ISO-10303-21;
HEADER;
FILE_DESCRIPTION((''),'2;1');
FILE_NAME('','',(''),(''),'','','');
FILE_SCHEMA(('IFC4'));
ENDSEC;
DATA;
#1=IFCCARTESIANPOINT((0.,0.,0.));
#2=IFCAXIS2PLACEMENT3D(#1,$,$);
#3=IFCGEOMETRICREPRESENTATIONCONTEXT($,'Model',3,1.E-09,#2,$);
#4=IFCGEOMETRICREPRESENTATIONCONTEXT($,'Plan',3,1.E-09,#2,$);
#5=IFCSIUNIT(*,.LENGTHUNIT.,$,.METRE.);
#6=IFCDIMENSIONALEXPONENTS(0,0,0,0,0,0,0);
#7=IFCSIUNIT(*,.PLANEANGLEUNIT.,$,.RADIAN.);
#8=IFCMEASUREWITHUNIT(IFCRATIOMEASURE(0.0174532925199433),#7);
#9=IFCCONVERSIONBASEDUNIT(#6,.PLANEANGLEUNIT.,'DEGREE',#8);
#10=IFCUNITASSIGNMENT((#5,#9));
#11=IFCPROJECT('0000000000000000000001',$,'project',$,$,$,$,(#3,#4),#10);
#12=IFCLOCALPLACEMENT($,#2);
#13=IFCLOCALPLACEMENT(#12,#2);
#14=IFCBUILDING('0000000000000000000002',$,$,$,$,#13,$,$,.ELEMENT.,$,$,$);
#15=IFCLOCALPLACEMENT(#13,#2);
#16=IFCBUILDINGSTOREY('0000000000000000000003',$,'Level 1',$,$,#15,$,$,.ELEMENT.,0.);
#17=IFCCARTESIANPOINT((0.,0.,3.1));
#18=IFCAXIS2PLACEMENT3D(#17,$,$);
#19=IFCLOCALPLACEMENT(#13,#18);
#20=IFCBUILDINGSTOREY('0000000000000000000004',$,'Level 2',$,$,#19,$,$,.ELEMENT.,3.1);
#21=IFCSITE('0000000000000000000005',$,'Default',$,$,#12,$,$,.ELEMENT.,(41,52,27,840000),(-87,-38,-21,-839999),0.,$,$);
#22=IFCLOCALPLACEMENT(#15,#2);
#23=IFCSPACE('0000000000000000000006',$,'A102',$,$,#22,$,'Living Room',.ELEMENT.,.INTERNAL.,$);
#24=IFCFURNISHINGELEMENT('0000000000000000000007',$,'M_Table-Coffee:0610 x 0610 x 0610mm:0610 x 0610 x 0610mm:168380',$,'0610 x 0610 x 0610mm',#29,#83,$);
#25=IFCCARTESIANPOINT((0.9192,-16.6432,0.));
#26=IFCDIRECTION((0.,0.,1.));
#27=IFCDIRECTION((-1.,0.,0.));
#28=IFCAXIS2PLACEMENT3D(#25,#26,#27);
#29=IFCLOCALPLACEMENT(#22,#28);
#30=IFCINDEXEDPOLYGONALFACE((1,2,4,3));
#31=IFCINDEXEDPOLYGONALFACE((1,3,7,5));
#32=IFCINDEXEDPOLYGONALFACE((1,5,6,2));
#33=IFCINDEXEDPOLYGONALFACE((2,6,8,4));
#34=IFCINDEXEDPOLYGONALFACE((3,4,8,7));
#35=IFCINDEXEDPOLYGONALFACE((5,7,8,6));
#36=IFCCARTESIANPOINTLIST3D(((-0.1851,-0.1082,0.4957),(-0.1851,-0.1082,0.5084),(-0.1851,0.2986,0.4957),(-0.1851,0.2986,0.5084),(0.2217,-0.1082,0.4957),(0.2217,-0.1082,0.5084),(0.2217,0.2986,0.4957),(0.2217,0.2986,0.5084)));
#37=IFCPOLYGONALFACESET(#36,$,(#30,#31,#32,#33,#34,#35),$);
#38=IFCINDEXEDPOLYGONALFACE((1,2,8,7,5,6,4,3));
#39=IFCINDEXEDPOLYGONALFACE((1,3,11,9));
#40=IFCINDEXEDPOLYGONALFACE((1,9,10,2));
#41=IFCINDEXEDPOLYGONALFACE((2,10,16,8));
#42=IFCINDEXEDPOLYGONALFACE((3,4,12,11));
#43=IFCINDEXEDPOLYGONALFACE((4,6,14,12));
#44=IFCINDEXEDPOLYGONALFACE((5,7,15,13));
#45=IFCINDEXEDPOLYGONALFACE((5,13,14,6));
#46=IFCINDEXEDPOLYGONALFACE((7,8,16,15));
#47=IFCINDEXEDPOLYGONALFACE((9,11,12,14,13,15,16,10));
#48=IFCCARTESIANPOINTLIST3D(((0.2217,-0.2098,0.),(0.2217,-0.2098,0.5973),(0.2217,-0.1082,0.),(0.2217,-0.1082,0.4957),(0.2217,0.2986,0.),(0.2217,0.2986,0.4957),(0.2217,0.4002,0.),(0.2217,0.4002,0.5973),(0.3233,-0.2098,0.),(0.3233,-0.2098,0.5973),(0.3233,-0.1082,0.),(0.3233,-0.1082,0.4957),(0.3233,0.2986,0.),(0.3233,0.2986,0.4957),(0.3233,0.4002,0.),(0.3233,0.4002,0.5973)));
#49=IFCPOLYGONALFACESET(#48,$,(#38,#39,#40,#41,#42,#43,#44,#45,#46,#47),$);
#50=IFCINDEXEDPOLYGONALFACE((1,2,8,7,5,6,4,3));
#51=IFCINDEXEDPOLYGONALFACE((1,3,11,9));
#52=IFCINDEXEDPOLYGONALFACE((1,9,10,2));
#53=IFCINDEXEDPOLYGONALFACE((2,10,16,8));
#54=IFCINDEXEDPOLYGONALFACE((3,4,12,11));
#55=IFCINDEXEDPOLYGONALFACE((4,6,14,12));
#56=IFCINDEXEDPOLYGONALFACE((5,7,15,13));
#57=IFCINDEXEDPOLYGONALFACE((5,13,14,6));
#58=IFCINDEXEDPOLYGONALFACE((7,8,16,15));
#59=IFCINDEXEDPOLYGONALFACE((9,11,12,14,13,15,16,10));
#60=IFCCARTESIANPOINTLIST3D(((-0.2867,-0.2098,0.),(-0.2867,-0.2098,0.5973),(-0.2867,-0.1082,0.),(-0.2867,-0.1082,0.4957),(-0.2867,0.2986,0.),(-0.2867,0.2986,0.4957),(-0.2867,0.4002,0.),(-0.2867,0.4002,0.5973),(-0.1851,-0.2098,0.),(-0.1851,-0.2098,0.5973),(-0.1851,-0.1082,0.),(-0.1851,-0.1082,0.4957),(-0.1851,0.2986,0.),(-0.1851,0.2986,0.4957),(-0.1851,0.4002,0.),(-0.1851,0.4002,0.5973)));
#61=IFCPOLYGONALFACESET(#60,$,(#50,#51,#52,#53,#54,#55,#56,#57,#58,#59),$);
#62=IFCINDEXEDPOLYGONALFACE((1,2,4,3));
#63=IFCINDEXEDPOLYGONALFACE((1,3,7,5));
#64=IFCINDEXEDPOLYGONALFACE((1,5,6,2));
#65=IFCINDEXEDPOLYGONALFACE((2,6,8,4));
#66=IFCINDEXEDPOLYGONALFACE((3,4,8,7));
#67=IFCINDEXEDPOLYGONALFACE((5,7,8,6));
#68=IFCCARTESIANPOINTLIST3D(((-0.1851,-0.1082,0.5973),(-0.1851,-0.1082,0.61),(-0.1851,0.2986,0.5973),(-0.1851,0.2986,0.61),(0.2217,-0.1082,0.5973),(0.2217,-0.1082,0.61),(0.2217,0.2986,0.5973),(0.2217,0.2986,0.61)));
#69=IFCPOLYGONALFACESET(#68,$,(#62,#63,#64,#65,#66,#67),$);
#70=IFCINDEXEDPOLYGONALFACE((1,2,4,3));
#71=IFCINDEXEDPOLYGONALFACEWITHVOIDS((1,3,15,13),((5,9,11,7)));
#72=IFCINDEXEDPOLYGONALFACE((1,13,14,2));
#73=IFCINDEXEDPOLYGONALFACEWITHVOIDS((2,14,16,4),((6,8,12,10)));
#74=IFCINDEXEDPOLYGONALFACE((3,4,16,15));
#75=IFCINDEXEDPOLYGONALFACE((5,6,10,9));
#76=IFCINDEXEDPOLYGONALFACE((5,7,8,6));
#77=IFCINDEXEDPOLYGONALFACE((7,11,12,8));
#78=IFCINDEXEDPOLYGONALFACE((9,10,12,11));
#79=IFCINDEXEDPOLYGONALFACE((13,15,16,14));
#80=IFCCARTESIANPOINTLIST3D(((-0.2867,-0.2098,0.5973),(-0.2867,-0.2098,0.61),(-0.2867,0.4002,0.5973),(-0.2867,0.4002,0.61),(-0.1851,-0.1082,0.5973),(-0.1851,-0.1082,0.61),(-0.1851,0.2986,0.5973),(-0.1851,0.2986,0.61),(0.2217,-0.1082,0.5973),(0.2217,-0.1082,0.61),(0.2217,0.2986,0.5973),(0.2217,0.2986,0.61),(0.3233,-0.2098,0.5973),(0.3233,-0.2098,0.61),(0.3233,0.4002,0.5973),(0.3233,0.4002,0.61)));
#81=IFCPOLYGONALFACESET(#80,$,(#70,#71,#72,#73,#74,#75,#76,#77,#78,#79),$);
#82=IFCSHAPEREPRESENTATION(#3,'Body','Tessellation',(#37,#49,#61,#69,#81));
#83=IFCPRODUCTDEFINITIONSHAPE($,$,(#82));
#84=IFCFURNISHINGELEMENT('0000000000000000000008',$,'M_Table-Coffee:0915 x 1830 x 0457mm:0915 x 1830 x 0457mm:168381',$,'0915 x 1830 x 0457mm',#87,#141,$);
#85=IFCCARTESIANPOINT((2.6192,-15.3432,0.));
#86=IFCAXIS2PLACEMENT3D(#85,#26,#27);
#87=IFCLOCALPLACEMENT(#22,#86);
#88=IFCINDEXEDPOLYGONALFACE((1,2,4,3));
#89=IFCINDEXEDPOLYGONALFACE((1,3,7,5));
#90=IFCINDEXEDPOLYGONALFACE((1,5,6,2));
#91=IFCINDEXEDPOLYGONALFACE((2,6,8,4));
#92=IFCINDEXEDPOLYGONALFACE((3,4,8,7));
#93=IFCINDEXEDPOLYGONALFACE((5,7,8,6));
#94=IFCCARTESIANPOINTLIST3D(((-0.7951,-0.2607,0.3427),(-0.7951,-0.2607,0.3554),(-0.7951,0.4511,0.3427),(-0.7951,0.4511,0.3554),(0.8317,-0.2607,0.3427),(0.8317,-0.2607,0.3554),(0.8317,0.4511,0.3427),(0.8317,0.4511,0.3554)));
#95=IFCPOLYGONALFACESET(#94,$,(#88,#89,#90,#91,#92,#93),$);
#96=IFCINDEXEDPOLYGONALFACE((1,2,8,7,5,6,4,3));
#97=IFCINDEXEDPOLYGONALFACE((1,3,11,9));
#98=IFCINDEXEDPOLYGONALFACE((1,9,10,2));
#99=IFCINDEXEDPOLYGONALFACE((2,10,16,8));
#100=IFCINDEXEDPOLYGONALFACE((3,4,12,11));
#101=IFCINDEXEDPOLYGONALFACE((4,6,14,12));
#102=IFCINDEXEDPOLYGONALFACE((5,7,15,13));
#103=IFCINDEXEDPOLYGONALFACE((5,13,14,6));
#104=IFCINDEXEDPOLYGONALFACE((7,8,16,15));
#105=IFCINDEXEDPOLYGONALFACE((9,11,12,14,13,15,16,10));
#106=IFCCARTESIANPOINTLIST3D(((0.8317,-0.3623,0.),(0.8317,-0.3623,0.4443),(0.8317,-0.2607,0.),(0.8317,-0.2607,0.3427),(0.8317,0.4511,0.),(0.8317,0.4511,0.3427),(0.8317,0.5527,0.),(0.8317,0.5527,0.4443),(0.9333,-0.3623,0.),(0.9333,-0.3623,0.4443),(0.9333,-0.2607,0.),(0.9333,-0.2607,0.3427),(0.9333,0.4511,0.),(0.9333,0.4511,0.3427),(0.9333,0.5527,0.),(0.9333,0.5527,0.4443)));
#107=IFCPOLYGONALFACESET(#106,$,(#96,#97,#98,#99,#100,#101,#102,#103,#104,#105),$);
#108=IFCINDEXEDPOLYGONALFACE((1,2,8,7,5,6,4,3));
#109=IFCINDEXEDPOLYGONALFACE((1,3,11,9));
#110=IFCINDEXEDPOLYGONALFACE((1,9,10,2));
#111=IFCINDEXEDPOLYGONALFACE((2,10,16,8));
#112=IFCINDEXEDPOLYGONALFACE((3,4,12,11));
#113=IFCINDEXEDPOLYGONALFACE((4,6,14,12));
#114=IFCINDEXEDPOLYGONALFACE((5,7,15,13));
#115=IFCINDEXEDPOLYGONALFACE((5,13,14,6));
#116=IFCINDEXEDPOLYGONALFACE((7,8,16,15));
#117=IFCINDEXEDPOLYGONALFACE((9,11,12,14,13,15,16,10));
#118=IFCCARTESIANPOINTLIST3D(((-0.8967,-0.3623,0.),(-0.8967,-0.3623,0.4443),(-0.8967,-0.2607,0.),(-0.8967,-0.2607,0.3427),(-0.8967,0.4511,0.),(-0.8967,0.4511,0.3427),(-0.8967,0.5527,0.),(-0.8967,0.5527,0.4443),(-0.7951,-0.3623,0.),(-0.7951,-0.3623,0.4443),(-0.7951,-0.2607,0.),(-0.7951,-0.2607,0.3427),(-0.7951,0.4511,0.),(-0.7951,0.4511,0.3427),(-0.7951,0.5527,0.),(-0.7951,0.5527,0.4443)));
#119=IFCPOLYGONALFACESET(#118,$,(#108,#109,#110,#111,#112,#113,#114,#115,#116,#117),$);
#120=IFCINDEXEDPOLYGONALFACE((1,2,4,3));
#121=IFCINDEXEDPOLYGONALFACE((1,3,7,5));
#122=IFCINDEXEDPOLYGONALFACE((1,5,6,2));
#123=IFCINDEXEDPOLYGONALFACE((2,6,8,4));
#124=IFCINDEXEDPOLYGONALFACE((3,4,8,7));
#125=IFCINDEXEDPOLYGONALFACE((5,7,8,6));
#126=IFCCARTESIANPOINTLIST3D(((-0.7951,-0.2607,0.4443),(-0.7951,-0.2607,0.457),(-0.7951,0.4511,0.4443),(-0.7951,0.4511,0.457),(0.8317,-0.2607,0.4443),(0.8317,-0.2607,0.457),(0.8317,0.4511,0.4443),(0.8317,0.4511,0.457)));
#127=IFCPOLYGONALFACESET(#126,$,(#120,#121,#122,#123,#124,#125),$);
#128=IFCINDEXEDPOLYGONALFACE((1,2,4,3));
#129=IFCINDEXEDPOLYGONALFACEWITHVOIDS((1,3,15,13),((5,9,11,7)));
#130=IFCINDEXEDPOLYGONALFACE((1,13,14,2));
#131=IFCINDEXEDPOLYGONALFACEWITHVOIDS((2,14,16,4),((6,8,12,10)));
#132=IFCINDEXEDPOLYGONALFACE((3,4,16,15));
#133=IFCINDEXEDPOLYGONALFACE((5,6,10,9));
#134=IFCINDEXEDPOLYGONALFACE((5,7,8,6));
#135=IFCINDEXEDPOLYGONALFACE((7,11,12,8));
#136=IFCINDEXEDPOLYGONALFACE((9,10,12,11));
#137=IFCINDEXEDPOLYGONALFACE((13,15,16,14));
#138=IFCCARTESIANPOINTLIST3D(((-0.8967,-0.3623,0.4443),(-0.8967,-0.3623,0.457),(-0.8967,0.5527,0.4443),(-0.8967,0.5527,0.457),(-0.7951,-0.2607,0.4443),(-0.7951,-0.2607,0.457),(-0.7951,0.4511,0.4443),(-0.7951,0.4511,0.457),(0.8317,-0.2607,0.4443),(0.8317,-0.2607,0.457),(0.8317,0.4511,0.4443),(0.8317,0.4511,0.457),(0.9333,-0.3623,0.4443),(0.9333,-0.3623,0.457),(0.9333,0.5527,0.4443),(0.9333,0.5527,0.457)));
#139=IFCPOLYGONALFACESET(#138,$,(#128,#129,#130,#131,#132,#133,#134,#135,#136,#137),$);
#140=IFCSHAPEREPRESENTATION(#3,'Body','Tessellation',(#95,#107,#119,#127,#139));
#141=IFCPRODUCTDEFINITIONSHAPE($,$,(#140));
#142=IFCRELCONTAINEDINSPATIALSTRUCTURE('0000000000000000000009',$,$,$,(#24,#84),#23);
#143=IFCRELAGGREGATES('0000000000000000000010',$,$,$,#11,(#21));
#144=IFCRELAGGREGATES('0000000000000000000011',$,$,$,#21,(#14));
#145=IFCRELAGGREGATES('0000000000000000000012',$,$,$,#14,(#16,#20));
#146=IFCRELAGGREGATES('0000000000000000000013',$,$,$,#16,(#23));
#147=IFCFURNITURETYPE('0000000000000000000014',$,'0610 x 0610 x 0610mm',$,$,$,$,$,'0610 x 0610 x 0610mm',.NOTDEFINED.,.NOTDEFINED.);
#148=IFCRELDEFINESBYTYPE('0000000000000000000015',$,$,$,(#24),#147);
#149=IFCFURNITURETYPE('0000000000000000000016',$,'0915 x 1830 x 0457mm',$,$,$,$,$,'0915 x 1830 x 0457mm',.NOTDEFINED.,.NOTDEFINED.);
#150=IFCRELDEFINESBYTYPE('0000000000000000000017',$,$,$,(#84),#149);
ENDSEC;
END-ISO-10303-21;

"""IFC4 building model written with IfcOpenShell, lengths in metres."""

from ifc_helpers import new_model, entity, si_unit, converted_unit, frame, origin, origin_2d_with_axis, place, context, project, spatial, polyline, rectangle, outline, extrude, source, transform, mapped, type_object, type_shapes, element, save


model = new_model("IFC4")

# Units and contexts
model_context = context("Model", 3, precision=1e-09, world=origin())
plan_context = context("Plan", 3, precision=1e-09, world=origin())
ifc_project = project(units=[si_unit("LENGTHUNIT", "METRE"), converted_unit("PLANEANGLEUNIT", "DEGREE", entity("IfcRatioMeasure", 0.0174532925199433), si_unit("PLANEANGLEUNIT", "RADIAN"), dimensions=[0, 0, 0, 0, 0, 0, 0])], contexts=[model_context, plan_context])

# Site, building, storey
site_placement = place(None, origin())
site = spatial("IfcSite", under=ifc_project, at=site_placement, Name="Default", CompositionType="ELEMENT", RefLatitude=(41, 52, 27, 840000), RefLongitude=(-87, -38, -21, -839999), RefElevation=0.0)
building_placement = place(site_placement, origin())
building = spatial("IfcBuilding", under=site, at=building_placement, CompositionType="ELEMENT")
storey_1_placement = place(building_placement, origin())
storey_1 = spatial("IfcBuildingStorey", under=building, at=storey_1_placement, Name="Level 1", CompositionType="ELEMENT", Elevation=0.0)

# Shared definitions
storey_2_placement = place(building_placement, frame((0.0, 0.0, 3.1)))
storey_2 = spatial("IfcBuildingStorey", under=building, at=storey_2_placement, Name="Level 2", CompositionType="ELEMENT", Elevation=3.1)

# Shared definitions
space_1_placement = place(storey_1_placement, origin())
space_1 = spatial("IfcSpace", under=storey_1, at=space_1_placement, Name="A102", LongName="Living Room", CompositionType="ELEMENT", PredefinedType="INTERNAL")

# Furnishing elements
furniture_type_1 = type_object("IfcFurnitureType", Name="0610 x 0610 x 0610mm", ElementType="0610 x 0610 x 0610mm", AssemblyPlace="NOTDEFINED")
shared_shape_1 = source(origin(), model_context, "Body", "SweptSolid", [
    extrude(rectangle(XDim=0.4068, YDim=0.4068, at=origin_2d_with_axis()), frame((0.0183, 0.0952, 0.4957), z_axis=(0.0, 0.0, 1.0), x_axis=(-1.0, 0.0, 0.0)), (0.0, 0.0, 1.0), 0.0127),
    extrude(outline(polyline([(-0.2732, -0.305), (0.324, -0.305), (0.324, 0.305), (-0.2732, 0.305), (-0.2732, 0.2034), (0.2225, 0.2034), (0.2225, -0.2034), (-0.2732, -0.2034), (-0.2732, -0.305)])), frame((0.2217, 0.0952, 0.2732), z_axis=(1.0, 0.0, 0.0), x_axis=(0.0, 0.0, 1.0)), (0.0, 0.0, 1.0), 0.1016),
    extrude(outline(polyline([(-0.305, -0.3241), (0.305, -0.3241), (0.305, 0.2733), (0.2034, 0.2733), (0.2034, -0.2224), (-0.2034, -0.2224), (-0.2034, 0.2733), (-0.305, 0.2733), (-0.305, -0.3241)])), frame((-0.2867, 0.0952, 0.2733), z_axis=(1.0, 0.0, 0.0), x_axis=(0.0, -1.0, 0.0)), (0.0, 0.0, 1.0), 0.1016),
    extrude(rectangle(XDim=0.4068, YDim=0.4068, at=origin_2d_with_axis()), frame((0.0183, 0.0952, 0.5973), z_axis=(0.0, 0.0, 1.0), x_axis=(-1.0, 0.0, 0.0)), (0.0, 0.0, 1.0), 0.0127),
    extrude(outline(polyline([(-0.305, -0.305), (0.305, -0.305), (0.305, 0.305), (-0.305, 0.305), (-0.305, -0.305)]), holes=[polyline([(-0.2034, -0.2034), (-0.2034, 0.2034), (0.2034, 0.2034), (0.2034, -0.2034), (-0.2034, -0.2034)])]), frame((0.0183, 0.0952, 0.5973), z_axis=(0.0, 0.0, 1.0), x_axis=(-1.0, 0.0, 0.0)), (0.0, 0.0, 1.0), 0.0127),
])
type_shapes(furniture_type_1, [shared_shape_1])
for number, where, z_axis, x_axis, name in (
    (1, (0.9192, -16.6432, 0.0), (0.0, 0.0, 1.0), (-1.0, 0.0, 0.0), "M_Table-Coffee:0610 x 0610 x 0610mm:0610 x 0610 x 0610mm:168380"),
):
    element("IfcFurnishingElement", number, at=place(space_1_placement, frame(where, z_axis=z_axis, x_axis=x_axis)), inside=space_1, type_object=furniture_type_1, Name=name, ObjectType="0610 x 0610 x 0610mm", context=model_context, shape_type="MappedRepresentation", body=[
        mapped(shared_shape_1, transform((0.0, 0.0, 0.0), scale=1.0)),
    ])
furniture_type_2 = type_object("IfcFurnitureType", Name="0915 x 1830 x 0457mm", ElementType="0915 x 1830 x 0457mm", AssemblyPlace="NOTDEFINED")
shared_shape_2 = source(origin(), model_context, "Body", "SweptSolid", [
    extrude(rectangle(XDim=1.6268, YDim=0.7118, at=origin_2d_with_axis()), frame((0.0183, 0.0952, 0.3427), z_axis=(0.0, 0.0, 1.0), x_axis=(-1.0, 0.0, 0.0)), (0.0, 0.0, 1.0), 0.0127),
    extrude(outline(polyline([(-0.1967, -0.4575), (0.2475, -0.4575), (0.2475, 0.4575), (-0.1967, 0.4575), (-0.1967, 0.3559), (0.146, 0.3559), (0.146, -0.3559), (-0.1967, -0.3559), (-0.1967, -0.4575)])), frame((0.8317, 0.0952, 0.1967), z_axis=(1.0, 0.0, 0.0), x_axis=(0.0, 0.0, 1.0)), (0.0, 0.0, 1.0), 0.1016),
    extrude(outline(polyline([(-0.4575, -0.2476), (0.4575, -0.2476), (0.4575, 0.1968), (0.3559, 0.1968), (0.3559, -0.1459), (-0.3559, -0.1459), (-0.3559, 0.1968), (-0.4575, 0.1968), (-0.4575, -0.2476)])), frame((-0.8967, 0.0952, 0.1968), z_axis=(1.0, 0.0, 0.0), x_axis=(0.0, -1.0, 0.0)), (0.0, 0.0, 1.0), 0.1016),
    extrude(rectangle(XDim=1.6268, YDim=0.7118, at=origin_2d_with_axis()), frame((0.0183, 0.0952, 0.4443), z_axis=(0.0, 0.0, 1.0), x_axis=(-1.0, 0.0, 0.0)), (0.0, 0.0, 1.0), 0.0127),
    extrude(outline(polyline([(-0.915, -0.4575), (0.915, -0.4575), (0.915, 0.4575), (-0.915, 0.4575), (-0.915, -0.4575)]), holes=[polyline([(-0.8134, -0.3559), (-0.8134, 0.3559), (0.8134, 0.3559), (0.8134, -0.3559), (-0.8134, -0.3559)])]), frame((0.0183, 0.0952, 0.4443), z_axis=(0.0, 0.0, 1.0), x_axis=(-1.0, 0.0, 0.0)), (0.0, 0.0, 1.0), 0.0127),
])
type_shapes(furniture_type_2, [shared_shape_2])
furnishing_1_placement = place(space_1_placement, frame((2.6192, -15.3432, 0.0), z_axis=(0.0, 0.0, 1.0), x_axis=(-1.0, 0.0, 0.0)))
element("IfcFurnishingElement", 2, at=furnishing_1_placement, inside=space_1, type_object=furniture_type_2, Name="M_Table-Coffee:0915 x 1830 x 0457mm:0915 x 1830 x 0457mm:168381", ObjectType="0915 x 1830 x 0457mm", context=model_context, shape_type="MappedRepresentation", body=[
    mapped(shared_shape_2, transform((0.0, 0.0, 0.0), scale=1.0)),
])

save(model, "model.ifc")
